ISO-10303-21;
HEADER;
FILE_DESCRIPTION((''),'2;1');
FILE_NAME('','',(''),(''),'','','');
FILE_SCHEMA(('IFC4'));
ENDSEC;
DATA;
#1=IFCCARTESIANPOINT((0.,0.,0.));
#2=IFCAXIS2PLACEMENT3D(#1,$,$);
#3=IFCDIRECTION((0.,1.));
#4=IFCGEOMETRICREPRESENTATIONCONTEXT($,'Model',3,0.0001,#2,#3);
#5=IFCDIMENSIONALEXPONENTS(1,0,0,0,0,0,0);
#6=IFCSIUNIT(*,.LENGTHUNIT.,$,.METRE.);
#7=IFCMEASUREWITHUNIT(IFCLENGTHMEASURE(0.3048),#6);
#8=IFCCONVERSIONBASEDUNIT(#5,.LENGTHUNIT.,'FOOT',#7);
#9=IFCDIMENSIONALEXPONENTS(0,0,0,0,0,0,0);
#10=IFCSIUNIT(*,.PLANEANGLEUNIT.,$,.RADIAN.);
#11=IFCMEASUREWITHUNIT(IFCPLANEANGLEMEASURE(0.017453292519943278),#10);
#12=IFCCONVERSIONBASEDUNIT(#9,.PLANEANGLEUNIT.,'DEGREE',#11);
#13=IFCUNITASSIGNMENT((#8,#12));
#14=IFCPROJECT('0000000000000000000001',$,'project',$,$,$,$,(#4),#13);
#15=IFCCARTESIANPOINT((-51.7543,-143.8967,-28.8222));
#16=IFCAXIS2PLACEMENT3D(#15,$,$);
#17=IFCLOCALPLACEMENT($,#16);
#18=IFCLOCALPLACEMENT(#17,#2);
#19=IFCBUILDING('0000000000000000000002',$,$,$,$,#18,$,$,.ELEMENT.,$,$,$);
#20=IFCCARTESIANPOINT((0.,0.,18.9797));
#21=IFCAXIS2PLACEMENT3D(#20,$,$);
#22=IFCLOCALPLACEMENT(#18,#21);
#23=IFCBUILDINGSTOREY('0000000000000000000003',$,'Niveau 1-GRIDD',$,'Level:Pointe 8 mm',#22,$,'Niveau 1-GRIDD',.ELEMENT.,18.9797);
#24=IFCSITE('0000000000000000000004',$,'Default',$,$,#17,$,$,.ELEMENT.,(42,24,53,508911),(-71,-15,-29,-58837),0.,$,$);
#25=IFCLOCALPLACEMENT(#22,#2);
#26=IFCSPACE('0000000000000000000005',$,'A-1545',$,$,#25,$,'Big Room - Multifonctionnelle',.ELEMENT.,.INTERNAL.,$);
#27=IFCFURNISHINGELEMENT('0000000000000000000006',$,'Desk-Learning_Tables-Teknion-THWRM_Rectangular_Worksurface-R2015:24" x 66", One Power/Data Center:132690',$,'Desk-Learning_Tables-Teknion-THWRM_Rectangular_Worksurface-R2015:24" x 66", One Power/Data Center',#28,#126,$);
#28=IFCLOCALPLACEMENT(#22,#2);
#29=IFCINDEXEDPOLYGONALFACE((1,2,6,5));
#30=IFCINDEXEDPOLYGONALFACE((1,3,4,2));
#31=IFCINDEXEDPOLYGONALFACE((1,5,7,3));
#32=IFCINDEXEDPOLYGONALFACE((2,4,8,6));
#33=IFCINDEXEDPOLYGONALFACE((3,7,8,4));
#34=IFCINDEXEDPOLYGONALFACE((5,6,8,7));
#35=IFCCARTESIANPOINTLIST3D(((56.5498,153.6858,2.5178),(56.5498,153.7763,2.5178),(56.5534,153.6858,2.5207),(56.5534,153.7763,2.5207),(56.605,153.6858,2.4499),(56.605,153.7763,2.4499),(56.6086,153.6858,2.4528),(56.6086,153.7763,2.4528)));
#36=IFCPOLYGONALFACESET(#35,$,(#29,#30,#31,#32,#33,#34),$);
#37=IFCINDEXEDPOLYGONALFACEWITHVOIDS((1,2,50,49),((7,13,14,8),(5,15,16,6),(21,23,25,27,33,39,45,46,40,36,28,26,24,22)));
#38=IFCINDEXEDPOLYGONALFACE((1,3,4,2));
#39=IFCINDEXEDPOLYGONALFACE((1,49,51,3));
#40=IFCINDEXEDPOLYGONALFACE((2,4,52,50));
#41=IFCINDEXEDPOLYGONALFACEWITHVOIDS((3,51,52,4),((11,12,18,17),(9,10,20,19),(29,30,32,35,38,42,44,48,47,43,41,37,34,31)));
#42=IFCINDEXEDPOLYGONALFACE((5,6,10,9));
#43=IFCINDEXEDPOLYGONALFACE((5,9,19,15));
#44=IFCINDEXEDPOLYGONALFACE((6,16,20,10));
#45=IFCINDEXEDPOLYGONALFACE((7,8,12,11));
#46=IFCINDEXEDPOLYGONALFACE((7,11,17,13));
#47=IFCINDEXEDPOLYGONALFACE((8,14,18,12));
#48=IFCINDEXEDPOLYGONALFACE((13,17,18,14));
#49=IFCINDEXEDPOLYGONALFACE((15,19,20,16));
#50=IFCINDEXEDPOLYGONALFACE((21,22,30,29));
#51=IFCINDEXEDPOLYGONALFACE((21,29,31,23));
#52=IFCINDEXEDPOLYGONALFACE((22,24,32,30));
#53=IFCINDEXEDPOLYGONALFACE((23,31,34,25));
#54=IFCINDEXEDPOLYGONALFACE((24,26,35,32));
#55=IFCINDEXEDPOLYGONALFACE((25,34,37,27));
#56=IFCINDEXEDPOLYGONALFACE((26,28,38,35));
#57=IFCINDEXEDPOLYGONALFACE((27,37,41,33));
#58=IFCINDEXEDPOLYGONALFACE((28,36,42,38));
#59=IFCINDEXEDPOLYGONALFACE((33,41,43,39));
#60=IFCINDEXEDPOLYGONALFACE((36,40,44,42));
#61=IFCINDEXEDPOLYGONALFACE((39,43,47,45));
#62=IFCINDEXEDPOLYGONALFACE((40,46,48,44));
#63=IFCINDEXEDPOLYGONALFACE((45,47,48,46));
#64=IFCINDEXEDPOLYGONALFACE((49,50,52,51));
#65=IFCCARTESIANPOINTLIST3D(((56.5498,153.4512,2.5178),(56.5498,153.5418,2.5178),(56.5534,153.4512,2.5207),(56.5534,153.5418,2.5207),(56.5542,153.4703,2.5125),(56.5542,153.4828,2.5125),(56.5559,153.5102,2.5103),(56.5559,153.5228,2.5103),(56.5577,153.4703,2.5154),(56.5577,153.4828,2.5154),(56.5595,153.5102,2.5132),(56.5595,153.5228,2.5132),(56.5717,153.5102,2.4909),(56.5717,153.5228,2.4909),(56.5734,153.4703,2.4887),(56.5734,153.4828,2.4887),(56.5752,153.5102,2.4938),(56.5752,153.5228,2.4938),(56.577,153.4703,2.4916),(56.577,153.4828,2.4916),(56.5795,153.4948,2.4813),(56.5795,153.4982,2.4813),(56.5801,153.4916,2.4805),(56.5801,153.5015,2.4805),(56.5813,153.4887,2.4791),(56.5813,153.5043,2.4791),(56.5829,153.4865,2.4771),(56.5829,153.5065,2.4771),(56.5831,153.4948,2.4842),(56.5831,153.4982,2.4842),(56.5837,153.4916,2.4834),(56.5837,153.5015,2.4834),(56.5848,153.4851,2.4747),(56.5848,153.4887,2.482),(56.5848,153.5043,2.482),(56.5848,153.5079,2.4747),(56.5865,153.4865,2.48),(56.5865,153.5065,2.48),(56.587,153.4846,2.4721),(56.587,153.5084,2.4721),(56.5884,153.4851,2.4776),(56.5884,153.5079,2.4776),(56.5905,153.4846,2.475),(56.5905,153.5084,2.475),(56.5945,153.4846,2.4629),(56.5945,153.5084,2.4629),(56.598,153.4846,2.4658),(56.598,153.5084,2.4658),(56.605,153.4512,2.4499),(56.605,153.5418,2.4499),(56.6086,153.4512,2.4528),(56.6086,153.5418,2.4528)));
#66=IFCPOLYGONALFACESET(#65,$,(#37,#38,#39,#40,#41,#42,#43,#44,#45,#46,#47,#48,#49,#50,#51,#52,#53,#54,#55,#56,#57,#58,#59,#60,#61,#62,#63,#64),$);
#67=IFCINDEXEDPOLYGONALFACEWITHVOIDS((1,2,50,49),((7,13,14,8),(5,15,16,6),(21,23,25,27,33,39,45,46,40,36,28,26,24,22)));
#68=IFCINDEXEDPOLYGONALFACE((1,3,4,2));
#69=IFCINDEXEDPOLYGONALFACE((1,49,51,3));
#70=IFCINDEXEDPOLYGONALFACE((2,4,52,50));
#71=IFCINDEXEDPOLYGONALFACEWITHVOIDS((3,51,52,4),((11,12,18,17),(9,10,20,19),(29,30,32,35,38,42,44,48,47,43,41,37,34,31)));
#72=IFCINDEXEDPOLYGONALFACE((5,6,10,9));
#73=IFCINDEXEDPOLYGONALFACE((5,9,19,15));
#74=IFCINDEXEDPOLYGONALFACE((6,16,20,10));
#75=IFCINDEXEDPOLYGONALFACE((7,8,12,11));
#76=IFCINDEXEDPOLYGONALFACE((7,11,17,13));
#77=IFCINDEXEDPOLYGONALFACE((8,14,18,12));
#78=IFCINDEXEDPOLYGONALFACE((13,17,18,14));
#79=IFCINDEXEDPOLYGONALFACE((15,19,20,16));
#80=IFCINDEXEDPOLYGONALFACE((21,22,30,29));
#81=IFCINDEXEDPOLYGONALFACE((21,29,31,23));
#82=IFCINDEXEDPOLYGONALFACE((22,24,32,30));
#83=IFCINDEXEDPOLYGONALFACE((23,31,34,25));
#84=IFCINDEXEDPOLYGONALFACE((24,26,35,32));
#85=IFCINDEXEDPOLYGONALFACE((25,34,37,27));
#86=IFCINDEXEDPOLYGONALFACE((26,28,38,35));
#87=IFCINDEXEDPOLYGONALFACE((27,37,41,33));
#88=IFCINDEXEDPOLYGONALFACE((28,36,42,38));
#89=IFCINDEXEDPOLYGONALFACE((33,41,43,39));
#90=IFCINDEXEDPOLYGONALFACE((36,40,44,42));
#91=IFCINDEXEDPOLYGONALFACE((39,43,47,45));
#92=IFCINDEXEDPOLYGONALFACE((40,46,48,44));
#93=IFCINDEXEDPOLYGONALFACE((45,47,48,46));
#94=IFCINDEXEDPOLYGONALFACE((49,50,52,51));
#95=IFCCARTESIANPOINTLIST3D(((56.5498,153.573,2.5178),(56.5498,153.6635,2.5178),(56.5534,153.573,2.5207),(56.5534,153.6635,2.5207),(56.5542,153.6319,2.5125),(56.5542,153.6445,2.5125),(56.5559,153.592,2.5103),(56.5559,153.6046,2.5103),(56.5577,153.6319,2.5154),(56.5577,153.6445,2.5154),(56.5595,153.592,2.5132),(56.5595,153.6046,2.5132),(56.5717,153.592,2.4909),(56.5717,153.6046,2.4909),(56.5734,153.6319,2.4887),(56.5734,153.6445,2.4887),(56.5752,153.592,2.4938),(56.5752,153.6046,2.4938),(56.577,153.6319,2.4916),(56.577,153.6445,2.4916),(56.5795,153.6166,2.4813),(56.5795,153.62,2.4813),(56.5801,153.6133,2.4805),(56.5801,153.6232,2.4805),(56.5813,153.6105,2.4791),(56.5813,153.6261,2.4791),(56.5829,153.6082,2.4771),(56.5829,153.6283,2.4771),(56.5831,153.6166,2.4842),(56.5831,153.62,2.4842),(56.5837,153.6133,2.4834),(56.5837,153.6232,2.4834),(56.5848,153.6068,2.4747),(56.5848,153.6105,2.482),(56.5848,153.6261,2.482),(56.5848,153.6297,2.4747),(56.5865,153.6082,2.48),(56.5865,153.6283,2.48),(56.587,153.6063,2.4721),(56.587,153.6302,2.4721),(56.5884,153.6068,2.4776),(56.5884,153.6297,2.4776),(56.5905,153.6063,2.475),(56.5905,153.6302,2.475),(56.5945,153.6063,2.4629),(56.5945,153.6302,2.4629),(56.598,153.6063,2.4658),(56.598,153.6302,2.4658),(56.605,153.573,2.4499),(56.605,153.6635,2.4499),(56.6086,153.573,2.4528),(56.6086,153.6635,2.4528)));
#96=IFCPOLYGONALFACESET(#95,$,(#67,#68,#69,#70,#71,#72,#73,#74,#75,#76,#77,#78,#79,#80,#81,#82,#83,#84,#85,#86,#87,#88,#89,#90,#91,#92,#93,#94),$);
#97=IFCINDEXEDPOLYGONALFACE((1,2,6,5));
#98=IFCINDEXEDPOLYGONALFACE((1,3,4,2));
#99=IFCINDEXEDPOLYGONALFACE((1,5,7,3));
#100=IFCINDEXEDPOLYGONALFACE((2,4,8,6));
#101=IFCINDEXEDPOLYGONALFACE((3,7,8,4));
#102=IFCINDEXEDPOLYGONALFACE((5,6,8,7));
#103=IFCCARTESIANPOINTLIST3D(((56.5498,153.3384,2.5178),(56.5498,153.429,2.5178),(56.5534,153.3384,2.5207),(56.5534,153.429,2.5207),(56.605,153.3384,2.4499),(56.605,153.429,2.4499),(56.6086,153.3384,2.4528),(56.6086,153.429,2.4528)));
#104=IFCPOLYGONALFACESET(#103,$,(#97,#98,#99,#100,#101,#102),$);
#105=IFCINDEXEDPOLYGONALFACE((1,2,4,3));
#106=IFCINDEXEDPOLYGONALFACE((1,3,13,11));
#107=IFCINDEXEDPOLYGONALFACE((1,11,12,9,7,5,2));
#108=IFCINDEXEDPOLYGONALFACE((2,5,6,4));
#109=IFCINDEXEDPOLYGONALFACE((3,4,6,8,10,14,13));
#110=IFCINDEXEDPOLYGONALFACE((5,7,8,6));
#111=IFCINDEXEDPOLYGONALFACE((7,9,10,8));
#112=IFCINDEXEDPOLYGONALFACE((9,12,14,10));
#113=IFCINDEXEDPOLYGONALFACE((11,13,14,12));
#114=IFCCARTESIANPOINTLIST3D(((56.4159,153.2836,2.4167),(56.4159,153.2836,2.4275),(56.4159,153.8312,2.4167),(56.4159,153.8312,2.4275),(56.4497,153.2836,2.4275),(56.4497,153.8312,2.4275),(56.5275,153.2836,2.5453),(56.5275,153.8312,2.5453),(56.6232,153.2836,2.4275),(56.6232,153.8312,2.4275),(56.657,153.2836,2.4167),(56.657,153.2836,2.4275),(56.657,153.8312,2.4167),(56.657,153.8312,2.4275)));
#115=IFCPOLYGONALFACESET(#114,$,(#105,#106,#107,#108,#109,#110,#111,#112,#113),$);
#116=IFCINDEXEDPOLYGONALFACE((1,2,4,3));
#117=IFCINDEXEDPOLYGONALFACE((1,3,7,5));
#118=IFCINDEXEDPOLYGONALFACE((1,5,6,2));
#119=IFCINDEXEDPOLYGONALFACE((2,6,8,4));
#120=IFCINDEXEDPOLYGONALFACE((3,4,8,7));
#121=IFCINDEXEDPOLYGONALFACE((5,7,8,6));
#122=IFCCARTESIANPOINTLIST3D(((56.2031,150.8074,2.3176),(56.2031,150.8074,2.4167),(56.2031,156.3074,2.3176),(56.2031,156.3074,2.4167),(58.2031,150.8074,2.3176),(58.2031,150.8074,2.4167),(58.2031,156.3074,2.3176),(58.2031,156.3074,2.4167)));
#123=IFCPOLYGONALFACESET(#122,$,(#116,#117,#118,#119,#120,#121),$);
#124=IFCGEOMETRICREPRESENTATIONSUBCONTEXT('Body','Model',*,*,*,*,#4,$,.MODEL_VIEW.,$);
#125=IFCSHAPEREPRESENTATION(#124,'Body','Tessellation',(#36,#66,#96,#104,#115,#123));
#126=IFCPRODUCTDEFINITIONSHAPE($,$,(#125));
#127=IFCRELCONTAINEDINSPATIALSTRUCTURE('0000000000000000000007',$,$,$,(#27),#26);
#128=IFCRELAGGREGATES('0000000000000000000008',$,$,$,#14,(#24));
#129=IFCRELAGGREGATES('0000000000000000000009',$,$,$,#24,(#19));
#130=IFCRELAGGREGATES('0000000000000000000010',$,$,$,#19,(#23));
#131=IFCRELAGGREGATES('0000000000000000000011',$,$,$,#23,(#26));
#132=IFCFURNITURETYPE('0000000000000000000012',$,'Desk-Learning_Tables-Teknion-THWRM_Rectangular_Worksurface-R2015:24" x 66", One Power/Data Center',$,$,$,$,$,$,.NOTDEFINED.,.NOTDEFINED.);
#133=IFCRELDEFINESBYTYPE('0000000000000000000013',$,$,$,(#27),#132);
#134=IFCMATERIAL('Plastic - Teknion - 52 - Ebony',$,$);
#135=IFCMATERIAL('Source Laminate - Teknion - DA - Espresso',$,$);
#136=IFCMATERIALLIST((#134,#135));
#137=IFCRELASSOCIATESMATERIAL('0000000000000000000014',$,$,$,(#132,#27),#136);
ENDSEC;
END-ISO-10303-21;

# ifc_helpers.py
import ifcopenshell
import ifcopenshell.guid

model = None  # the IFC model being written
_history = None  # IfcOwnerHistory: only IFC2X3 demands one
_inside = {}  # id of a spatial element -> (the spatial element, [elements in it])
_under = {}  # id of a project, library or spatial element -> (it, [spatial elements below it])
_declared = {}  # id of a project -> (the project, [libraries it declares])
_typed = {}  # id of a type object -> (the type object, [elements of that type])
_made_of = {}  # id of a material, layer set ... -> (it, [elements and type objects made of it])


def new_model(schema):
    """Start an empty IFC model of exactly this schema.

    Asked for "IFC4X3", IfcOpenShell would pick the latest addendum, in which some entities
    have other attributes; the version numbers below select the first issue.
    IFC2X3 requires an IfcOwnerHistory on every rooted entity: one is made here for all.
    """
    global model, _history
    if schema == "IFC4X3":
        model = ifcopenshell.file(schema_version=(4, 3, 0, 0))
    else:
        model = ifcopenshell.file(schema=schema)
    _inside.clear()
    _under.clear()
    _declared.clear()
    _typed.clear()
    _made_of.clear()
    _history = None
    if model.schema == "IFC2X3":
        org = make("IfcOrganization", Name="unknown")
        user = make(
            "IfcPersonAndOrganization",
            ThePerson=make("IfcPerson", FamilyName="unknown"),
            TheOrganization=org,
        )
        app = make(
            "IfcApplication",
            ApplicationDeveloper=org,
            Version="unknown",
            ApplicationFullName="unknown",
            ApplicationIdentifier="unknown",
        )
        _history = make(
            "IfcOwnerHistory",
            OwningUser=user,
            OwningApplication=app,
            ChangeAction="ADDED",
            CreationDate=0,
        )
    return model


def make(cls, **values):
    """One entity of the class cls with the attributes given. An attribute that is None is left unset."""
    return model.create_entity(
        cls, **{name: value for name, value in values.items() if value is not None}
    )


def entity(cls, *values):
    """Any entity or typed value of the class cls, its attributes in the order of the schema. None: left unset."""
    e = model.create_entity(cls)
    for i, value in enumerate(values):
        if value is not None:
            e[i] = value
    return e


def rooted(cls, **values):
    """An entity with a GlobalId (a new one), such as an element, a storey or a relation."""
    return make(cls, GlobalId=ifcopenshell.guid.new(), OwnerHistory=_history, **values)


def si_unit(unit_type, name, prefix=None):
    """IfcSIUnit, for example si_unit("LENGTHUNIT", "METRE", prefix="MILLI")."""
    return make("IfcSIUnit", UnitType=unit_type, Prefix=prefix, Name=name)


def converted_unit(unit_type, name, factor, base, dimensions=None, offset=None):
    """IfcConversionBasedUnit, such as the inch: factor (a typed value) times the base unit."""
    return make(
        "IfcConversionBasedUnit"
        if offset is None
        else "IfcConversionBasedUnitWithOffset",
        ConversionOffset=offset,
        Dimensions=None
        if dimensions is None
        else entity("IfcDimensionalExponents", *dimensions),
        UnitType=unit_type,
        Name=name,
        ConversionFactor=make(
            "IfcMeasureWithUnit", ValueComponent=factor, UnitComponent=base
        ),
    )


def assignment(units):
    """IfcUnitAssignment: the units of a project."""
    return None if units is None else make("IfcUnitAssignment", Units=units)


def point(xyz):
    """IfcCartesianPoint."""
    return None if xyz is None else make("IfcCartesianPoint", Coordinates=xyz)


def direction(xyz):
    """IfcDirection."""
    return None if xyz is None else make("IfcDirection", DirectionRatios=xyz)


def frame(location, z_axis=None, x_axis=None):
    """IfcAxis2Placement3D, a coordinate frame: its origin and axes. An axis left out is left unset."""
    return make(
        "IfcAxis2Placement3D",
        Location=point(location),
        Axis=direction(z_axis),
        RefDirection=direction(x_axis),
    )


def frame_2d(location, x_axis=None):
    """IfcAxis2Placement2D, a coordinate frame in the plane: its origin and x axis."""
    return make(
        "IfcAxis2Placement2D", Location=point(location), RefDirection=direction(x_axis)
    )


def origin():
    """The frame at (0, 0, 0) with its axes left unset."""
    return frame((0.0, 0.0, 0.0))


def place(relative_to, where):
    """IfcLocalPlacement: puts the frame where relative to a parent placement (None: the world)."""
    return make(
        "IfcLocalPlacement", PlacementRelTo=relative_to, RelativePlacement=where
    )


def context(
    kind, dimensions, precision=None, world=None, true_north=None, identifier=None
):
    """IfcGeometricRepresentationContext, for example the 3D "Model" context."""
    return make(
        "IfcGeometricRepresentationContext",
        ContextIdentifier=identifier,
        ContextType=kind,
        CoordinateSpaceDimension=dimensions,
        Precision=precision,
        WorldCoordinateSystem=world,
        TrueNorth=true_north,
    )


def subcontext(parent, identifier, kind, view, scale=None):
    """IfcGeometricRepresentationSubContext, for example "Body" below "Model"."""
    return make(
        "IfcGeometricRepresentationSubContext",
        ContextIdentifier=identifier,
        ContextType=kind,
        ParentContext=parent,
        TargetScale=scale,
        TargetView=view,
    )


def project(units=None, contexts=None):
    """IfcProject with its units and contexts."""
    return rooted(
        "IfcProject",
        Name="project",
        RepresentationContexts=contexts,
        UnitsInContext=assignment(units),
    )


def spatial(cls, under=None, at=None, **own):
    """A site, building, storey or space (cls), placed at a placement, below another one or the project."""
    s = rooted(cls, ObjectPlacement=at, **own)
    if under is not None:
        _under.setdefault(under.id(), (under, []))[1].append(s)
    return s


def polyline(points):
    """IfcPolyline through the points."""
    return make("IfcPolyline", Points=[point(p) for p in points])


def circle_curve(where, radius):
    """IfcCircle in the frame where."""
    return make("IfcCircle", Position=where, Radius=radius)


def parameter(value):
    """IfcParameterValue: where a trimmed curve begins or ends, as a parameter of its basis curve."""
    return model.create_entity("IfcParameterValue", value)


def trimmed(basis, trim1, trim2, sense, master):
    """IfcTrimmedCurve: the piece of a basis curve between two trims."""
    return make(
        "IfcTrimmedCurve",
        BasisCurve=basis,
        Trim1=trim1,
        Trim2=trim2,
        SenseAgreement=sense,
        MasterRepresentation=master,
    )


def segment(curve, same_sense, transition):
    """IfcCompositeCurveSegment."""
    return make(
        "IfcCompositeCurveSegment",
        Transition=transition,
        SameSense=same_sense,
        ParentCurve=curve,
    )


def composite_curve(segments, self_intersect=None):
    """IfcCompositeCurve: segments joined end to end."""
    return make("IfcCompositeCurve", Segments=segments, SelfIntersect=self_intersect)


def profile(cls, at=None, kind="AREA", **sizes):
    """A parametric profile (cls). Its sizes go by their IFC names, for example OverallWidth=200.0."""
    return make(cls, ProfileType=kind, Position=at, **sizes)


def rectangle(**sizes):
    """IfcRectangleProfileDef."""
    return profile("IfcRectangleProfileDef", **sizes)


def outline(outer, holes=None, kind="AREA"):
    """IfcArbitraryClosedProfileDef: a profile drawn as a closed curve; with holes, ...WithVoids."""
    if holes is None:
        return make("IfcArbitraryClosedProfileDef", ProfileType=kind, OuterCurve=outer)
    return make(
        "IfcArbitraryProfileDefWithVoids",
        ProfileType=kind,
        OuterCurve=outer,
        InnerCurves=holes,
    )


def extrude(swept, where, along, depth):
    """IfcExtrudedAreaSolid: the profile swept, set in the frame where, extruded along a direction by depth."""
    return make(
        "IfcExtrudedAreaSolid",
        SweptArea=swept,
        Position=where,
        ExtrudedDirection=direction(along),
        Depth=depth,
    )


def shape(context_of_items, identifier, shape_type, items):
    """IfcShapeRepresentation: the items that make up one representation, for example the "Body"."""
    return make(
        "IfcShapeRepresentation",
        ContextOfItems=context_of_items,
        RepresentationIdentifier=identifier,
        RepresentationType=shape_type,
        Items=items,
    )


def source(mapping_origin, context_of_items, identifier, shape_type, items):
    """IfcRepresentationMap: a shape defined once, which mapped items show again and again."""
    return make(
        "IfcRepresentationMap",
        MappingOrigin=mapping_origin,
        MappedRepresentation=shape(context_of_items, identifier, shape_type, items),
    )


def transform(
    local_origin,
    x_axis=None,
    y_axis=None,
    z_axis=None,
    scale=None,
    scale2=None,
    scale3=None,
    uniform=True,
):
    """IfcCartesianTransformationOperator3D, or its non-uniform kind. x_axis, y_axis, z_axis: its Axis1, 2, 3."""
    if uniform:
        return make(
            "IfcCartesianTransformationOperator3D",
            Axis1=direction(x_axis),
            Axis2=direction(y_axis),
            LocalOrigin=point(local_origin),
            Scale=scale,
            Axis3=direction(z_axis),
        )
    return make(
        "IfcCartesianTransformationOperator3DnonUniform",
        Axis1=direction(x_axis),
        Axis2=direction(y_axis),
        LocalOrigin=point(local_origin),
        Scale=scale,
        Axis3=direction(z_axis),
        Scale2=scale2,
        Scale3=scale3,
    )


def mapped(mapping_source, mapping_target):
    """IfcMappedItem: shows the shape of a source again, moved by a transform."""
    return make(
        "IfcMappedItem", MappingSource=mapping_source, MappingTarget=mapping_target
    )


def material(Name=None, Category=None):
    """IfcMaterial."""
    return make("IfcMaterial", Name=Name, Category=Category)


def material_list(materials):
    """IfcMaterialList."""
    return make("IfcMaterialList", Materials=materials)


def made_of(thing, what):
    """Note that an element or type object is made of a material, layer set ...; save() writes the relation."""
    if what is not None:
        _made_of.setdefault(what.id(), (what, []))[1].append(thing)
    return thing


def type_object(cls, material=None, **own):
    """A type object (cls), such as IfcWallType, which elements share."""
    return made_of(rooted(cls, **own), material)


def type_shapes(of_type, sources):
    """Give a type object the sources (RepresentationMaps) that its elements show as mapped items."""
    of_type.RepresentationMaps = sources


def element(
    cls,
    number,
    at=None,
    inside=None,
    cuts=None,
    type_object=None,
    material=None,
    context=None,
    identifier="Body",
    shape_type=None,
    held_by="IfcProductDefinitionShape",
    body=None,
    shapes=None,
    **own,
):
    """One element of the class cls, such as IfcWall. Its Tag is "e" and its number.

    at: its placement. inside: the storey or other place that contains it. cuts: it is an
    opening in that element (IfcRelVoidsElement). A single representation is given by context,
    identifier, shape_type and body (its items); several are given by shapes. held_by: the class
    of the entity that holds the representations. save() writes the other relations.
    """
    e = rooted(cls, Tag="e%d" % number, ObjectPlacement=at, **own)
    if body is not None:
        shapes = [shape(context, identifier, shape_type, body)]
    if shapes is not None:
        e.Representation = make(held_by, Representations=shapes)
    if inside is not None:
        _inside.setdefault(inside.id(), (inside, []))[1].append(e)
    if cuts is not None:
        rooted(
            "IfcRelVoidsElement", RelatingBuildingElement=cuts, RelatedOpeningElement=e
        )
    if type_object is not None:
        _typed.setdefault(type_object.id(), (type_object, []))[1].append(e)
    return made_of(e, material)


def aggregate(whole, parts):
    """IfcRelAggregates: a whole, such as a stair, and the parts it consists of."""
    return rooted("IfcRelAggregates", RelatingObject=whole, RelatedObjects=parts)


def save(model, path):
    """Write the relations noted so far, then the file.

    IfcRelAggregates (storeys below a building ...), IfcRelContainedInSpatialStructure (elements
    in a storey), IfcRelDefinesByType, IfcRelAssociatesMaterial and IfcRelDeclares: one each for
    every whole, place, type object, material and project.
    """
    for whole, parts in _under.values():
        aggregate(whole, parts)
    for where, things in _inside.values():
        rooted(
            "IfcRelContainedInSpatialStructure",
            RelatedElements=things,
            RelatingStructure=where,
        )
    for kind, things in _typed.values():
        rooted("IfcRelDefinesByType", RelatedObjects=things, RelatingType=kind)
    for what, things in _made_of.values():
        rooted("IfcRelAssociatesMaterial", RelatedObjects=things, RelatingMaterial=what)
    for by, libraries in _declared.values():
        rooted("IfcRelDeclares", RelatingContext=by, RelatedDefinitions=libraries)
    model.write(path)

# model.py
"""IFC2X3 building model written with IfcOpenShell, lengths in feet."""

from ifc_helpers import new_model, entity, si_unit, converted_unit, direction, frame, frame_2d, origin, place, context, subcontext, project, spatial, polyline, circle_curve, parameter, trimmed, segment, composite_curve, rectangle, outline, extrude, source, transform, mapped, material, material_list, type_object, type_shapes, element, save


model = new_model("IFC2X3")

# Units and contexts
model_context = context("Model", 3, precision=0.0001, world=origin(), true_north=direction((0.0, 1.0)))
body_context = subcontext(model_context, "Body", "Model", "MODEL_VIEW")
ifc_project = project(units=[converted_unit("LENGTHUNIT", "FOOT", entity("IfcLengthMeasure", 0.3048), si_unit("LENGTHUNIT", "METRE"), dimensions=[1, 0, 0, 0, 0, 0, 0]), converted_unit("PLANEANGLEUNIT", "DEGREE", entity("IfcPlaneAngleMeasure", 0.017453292519943278), si_unit("PLANEANGLEUNIT", "RADIAN"), dimensions=[0, 0, 0, 0, 0, 0, 0])], contexts=[model_context])

# Site, building, storey
site_placement = place(None, frame((-51.7543, -143.8967, -28.8222)))
site = spatial("IfcSite", under=ifc_project, at=site_placement, Name="Default", CompositionType="ELEMENT", RefLatitude=(42, 24, 53, 508911), RefLongitude=(-71, -15, -29, -58837), RefElevation=0.0)
building_placement = place(site_placement, origin())
building = spatial("IfcBuilding", under=site, at=building_placement, CompositionType="ELEMENT")
storey_placement = place(building_placement, frame((0.0, 0.0, 18.9797)))
storey = spatial("IfcBuildingStorey", under=building, at=storey_placement, Name="Niveau 1-GRIDD", ObjectType="Level:Pointe 8 mm", LongName="Niveau 1-GRIDD", CompositionType="ELEMENT", Elevation=18.9797)

# Shared definitions
space_placement = place(storey_placement, origin())
space = spatial("IfcSpace", under=storey, at=space_placement, Name="A-1545", LongName="Big Room - Multifonctionnelle", CompositionType="ELEMENT", InteriorOrExteriorSpace="INTERNAL")

# Furnishing element
ifc_material_1 = material(Name="Plastic - Teknion - 52 - Ebony")
ifc_material_2 = material(Name="Source Laminate - Teknion - DA - Espresso")
ifc_material_list_1 = material_list([ifc_material_1, ifc_material_2])
furniture_type_1 = type_object("IfcFurnitureType", Name="Desk-Learning_Tables-Teknion-THWRM_Rectangular_Worksurface-R2015:24\" x 66\", One Power/Data Center", AssemblyPlace="NOTDEFINED", material=ifc_material_list_1)
shared_shape_1 = source(origin(), body_context, "Body", "SweptSolid", [
    extrude(rectangle(XDim=0.0875, YDim=0.0046, at=frame_2d((0.0, 0.0), x_axis=(0.0, 1.0))), frame((0.1284, 0.6239, 2.4853), z_axis=(1.0, 0.0, 0.0), x_axis=(0.0, 0.776046, -0.630676)), (0.0, 0.0, 1.0), 0.0906),
    extrude(outline(polyline([(-0.0453, -0.0438), (0.0453, -0.0438), (0.0453, 0.0438), (-0.0453, 0.0438), (-0.0453, -0.0438)]), holes=[polyline([(-0.0262, -0.0063), (-0.0137, -0.0063), (-0.0137, -0.0369), (-0.0262, -0.0369), (-0.0262, -0.0063)]), polyline([(0.0137, -0.0341), (0.0137, -0.0091), (0.0262, -0.0091), (0.0262, -0.0341), (0.0137, -0.0341)]), composite_curve([segment(polyline([(-0.0119, 0.027), (0.0119, 0.027)]), True, "CONTINUOUS"), segment(polyline([(0.0119, 0.027), (0.0119, 0.0151)]), True, "CONTINUOUS"), segment(trimmed(circle_curve(frame_2d((0.0, 0.0151), x_axis=(0.0, -1.0)), 0.0119), [parameter(270.0)], [parameter(90.0)], True, "PARAMETER"), False, "CONTINUOUS"), segment(polyline([(-0.0119, 0.0151), (-0.0119, 0.027)]), True, "CONTINUOUS")], self_intersect=False)]), frame((-0.0609, 0.6221, 2.4867), z_axis=(0.0, 0.776046, -0.630676), x_axis=(1.0, 0.0, 0.0)), (0.0, 0.0, 1.0), 0.0046),
    extrude(outline(polyline([(-0.0438, -0.0453), (0.0438, -0.0453), (0.0438, 0.0453), (-0.0438, 0.0453), (-0.0438, -0.0453)]), holes=[polyline([(-0.0063, -0.0262), (-0.0369, -0.0262), (-0.0369, -0.0137), (-0.0063, -0.0137), (-0.0063, -0.0262)]), polyline([(-0.0341, 0.0137), (-0.0341, 0.0262), (-0.0091, 0.0262), (-0.0091, 0.0137), (-0.0341, 0.0137)]), composite_curve([segment(polyline([(0.027, -0.0119), (0.0151, -0.0119)]), True, "CONTINUOUS"), segment(trimmed(circle_curve(frame_2d((0.0151, 0.0), x_axis=(-1.0, 0.0)), 0.0119), [parameter(270.0)], [parameter(90.0)], True, "PARAMETER"), False, "CONTINUOUS"), segment(polyline([(0.0151, 0.0119), (0.027, 0.0119)]), True, "CONTINUOUS"), segment(polyline([(0.027, 0.0119), (0.027, -0.0119)]), True, "CONTINUOUS")], self_intersect=False)]), frame((0.0609, 0.6221, 2.4867), z_axis=(0.0, 0.776046, -0.630676), x_axis=(0.0, -0.630676, -0.776046)), (0.0, 0.0, 1.0), 0.0046),
    extrude(rectangle(XDim=0.0875, YDim=0.0046, at=frame_2d((0.0, 0.0), x_axis=(0.0, 1.0))), frame((-0.219, 0.6239, 2.4853), z_axis=(1.0, 0.0, 0.0), x_axis=(0.0, 0.776046, -0.630676)), (0.0, 0.0, 1.0), 0.0906),
    extrude(outline(polyline([(-0.0586, -0.0638), (0.0826, -0.0638), (0.0371, 0.0811), (0.0557, 0.1093), (0.0467, 0.1152), (-0.0862, -0.086), (-0.0772, -0.092), (-0.0586, -0.0638)])), frame((-0.2738, 0.6679, 2.4412), z_axis=(1.0, 0.0, 0.0), x_axis=(0.0, -0.551103, 0.834437)), (0.0, 0.0, 1.0), 0.5475),
    extrude(rectangle(XDim=5.5, YDim=2.0, at=frame_2d((0.0, 0.0), x_axis=(1.0, 0.0))), frame((0.0, 0.0, 2.3176), z_axis=(0.0, 0.0, 1.0), x_axis=(-1.0, 0.0, 0.0)), (0.0, 0.0, 1.0), 0.0991),
])
type_shapes(furniture_type_1, [shared_shape_1])
for number, where, z_axis, x_axis, name in (
    (1, (57.2031, 153.5574, 0.0), (0.0, 0.0, 1.0), (0.0, 1.0, 0.0), "Desk-Learning_Tables-Teknion-THWRM_Rectangular_Worksurface-R2015:24\" x 66\", One Power/Data Center:132690"),
):
    element("IfcFurnishingElement", number, at=place(space_placement, frame(where, z_axis=z_axis, x_axis=x_axis)), inside=space, type_object=furniture_type_1, material=ifc_material_list_1, Name=name, ObjectType="Desk-Learning_Tables-Teknion-THWRM_Rectangular_Worksurface-R2015:24\" x 66\", One Power/Data Center", context=body_context, shape_type="MappedRepresentation", body=[
        mapped(shared_shape_1, transform((0.0, 0.0, 0.0), scale=1.0)),
    ])

save(model, "model.ifc")
